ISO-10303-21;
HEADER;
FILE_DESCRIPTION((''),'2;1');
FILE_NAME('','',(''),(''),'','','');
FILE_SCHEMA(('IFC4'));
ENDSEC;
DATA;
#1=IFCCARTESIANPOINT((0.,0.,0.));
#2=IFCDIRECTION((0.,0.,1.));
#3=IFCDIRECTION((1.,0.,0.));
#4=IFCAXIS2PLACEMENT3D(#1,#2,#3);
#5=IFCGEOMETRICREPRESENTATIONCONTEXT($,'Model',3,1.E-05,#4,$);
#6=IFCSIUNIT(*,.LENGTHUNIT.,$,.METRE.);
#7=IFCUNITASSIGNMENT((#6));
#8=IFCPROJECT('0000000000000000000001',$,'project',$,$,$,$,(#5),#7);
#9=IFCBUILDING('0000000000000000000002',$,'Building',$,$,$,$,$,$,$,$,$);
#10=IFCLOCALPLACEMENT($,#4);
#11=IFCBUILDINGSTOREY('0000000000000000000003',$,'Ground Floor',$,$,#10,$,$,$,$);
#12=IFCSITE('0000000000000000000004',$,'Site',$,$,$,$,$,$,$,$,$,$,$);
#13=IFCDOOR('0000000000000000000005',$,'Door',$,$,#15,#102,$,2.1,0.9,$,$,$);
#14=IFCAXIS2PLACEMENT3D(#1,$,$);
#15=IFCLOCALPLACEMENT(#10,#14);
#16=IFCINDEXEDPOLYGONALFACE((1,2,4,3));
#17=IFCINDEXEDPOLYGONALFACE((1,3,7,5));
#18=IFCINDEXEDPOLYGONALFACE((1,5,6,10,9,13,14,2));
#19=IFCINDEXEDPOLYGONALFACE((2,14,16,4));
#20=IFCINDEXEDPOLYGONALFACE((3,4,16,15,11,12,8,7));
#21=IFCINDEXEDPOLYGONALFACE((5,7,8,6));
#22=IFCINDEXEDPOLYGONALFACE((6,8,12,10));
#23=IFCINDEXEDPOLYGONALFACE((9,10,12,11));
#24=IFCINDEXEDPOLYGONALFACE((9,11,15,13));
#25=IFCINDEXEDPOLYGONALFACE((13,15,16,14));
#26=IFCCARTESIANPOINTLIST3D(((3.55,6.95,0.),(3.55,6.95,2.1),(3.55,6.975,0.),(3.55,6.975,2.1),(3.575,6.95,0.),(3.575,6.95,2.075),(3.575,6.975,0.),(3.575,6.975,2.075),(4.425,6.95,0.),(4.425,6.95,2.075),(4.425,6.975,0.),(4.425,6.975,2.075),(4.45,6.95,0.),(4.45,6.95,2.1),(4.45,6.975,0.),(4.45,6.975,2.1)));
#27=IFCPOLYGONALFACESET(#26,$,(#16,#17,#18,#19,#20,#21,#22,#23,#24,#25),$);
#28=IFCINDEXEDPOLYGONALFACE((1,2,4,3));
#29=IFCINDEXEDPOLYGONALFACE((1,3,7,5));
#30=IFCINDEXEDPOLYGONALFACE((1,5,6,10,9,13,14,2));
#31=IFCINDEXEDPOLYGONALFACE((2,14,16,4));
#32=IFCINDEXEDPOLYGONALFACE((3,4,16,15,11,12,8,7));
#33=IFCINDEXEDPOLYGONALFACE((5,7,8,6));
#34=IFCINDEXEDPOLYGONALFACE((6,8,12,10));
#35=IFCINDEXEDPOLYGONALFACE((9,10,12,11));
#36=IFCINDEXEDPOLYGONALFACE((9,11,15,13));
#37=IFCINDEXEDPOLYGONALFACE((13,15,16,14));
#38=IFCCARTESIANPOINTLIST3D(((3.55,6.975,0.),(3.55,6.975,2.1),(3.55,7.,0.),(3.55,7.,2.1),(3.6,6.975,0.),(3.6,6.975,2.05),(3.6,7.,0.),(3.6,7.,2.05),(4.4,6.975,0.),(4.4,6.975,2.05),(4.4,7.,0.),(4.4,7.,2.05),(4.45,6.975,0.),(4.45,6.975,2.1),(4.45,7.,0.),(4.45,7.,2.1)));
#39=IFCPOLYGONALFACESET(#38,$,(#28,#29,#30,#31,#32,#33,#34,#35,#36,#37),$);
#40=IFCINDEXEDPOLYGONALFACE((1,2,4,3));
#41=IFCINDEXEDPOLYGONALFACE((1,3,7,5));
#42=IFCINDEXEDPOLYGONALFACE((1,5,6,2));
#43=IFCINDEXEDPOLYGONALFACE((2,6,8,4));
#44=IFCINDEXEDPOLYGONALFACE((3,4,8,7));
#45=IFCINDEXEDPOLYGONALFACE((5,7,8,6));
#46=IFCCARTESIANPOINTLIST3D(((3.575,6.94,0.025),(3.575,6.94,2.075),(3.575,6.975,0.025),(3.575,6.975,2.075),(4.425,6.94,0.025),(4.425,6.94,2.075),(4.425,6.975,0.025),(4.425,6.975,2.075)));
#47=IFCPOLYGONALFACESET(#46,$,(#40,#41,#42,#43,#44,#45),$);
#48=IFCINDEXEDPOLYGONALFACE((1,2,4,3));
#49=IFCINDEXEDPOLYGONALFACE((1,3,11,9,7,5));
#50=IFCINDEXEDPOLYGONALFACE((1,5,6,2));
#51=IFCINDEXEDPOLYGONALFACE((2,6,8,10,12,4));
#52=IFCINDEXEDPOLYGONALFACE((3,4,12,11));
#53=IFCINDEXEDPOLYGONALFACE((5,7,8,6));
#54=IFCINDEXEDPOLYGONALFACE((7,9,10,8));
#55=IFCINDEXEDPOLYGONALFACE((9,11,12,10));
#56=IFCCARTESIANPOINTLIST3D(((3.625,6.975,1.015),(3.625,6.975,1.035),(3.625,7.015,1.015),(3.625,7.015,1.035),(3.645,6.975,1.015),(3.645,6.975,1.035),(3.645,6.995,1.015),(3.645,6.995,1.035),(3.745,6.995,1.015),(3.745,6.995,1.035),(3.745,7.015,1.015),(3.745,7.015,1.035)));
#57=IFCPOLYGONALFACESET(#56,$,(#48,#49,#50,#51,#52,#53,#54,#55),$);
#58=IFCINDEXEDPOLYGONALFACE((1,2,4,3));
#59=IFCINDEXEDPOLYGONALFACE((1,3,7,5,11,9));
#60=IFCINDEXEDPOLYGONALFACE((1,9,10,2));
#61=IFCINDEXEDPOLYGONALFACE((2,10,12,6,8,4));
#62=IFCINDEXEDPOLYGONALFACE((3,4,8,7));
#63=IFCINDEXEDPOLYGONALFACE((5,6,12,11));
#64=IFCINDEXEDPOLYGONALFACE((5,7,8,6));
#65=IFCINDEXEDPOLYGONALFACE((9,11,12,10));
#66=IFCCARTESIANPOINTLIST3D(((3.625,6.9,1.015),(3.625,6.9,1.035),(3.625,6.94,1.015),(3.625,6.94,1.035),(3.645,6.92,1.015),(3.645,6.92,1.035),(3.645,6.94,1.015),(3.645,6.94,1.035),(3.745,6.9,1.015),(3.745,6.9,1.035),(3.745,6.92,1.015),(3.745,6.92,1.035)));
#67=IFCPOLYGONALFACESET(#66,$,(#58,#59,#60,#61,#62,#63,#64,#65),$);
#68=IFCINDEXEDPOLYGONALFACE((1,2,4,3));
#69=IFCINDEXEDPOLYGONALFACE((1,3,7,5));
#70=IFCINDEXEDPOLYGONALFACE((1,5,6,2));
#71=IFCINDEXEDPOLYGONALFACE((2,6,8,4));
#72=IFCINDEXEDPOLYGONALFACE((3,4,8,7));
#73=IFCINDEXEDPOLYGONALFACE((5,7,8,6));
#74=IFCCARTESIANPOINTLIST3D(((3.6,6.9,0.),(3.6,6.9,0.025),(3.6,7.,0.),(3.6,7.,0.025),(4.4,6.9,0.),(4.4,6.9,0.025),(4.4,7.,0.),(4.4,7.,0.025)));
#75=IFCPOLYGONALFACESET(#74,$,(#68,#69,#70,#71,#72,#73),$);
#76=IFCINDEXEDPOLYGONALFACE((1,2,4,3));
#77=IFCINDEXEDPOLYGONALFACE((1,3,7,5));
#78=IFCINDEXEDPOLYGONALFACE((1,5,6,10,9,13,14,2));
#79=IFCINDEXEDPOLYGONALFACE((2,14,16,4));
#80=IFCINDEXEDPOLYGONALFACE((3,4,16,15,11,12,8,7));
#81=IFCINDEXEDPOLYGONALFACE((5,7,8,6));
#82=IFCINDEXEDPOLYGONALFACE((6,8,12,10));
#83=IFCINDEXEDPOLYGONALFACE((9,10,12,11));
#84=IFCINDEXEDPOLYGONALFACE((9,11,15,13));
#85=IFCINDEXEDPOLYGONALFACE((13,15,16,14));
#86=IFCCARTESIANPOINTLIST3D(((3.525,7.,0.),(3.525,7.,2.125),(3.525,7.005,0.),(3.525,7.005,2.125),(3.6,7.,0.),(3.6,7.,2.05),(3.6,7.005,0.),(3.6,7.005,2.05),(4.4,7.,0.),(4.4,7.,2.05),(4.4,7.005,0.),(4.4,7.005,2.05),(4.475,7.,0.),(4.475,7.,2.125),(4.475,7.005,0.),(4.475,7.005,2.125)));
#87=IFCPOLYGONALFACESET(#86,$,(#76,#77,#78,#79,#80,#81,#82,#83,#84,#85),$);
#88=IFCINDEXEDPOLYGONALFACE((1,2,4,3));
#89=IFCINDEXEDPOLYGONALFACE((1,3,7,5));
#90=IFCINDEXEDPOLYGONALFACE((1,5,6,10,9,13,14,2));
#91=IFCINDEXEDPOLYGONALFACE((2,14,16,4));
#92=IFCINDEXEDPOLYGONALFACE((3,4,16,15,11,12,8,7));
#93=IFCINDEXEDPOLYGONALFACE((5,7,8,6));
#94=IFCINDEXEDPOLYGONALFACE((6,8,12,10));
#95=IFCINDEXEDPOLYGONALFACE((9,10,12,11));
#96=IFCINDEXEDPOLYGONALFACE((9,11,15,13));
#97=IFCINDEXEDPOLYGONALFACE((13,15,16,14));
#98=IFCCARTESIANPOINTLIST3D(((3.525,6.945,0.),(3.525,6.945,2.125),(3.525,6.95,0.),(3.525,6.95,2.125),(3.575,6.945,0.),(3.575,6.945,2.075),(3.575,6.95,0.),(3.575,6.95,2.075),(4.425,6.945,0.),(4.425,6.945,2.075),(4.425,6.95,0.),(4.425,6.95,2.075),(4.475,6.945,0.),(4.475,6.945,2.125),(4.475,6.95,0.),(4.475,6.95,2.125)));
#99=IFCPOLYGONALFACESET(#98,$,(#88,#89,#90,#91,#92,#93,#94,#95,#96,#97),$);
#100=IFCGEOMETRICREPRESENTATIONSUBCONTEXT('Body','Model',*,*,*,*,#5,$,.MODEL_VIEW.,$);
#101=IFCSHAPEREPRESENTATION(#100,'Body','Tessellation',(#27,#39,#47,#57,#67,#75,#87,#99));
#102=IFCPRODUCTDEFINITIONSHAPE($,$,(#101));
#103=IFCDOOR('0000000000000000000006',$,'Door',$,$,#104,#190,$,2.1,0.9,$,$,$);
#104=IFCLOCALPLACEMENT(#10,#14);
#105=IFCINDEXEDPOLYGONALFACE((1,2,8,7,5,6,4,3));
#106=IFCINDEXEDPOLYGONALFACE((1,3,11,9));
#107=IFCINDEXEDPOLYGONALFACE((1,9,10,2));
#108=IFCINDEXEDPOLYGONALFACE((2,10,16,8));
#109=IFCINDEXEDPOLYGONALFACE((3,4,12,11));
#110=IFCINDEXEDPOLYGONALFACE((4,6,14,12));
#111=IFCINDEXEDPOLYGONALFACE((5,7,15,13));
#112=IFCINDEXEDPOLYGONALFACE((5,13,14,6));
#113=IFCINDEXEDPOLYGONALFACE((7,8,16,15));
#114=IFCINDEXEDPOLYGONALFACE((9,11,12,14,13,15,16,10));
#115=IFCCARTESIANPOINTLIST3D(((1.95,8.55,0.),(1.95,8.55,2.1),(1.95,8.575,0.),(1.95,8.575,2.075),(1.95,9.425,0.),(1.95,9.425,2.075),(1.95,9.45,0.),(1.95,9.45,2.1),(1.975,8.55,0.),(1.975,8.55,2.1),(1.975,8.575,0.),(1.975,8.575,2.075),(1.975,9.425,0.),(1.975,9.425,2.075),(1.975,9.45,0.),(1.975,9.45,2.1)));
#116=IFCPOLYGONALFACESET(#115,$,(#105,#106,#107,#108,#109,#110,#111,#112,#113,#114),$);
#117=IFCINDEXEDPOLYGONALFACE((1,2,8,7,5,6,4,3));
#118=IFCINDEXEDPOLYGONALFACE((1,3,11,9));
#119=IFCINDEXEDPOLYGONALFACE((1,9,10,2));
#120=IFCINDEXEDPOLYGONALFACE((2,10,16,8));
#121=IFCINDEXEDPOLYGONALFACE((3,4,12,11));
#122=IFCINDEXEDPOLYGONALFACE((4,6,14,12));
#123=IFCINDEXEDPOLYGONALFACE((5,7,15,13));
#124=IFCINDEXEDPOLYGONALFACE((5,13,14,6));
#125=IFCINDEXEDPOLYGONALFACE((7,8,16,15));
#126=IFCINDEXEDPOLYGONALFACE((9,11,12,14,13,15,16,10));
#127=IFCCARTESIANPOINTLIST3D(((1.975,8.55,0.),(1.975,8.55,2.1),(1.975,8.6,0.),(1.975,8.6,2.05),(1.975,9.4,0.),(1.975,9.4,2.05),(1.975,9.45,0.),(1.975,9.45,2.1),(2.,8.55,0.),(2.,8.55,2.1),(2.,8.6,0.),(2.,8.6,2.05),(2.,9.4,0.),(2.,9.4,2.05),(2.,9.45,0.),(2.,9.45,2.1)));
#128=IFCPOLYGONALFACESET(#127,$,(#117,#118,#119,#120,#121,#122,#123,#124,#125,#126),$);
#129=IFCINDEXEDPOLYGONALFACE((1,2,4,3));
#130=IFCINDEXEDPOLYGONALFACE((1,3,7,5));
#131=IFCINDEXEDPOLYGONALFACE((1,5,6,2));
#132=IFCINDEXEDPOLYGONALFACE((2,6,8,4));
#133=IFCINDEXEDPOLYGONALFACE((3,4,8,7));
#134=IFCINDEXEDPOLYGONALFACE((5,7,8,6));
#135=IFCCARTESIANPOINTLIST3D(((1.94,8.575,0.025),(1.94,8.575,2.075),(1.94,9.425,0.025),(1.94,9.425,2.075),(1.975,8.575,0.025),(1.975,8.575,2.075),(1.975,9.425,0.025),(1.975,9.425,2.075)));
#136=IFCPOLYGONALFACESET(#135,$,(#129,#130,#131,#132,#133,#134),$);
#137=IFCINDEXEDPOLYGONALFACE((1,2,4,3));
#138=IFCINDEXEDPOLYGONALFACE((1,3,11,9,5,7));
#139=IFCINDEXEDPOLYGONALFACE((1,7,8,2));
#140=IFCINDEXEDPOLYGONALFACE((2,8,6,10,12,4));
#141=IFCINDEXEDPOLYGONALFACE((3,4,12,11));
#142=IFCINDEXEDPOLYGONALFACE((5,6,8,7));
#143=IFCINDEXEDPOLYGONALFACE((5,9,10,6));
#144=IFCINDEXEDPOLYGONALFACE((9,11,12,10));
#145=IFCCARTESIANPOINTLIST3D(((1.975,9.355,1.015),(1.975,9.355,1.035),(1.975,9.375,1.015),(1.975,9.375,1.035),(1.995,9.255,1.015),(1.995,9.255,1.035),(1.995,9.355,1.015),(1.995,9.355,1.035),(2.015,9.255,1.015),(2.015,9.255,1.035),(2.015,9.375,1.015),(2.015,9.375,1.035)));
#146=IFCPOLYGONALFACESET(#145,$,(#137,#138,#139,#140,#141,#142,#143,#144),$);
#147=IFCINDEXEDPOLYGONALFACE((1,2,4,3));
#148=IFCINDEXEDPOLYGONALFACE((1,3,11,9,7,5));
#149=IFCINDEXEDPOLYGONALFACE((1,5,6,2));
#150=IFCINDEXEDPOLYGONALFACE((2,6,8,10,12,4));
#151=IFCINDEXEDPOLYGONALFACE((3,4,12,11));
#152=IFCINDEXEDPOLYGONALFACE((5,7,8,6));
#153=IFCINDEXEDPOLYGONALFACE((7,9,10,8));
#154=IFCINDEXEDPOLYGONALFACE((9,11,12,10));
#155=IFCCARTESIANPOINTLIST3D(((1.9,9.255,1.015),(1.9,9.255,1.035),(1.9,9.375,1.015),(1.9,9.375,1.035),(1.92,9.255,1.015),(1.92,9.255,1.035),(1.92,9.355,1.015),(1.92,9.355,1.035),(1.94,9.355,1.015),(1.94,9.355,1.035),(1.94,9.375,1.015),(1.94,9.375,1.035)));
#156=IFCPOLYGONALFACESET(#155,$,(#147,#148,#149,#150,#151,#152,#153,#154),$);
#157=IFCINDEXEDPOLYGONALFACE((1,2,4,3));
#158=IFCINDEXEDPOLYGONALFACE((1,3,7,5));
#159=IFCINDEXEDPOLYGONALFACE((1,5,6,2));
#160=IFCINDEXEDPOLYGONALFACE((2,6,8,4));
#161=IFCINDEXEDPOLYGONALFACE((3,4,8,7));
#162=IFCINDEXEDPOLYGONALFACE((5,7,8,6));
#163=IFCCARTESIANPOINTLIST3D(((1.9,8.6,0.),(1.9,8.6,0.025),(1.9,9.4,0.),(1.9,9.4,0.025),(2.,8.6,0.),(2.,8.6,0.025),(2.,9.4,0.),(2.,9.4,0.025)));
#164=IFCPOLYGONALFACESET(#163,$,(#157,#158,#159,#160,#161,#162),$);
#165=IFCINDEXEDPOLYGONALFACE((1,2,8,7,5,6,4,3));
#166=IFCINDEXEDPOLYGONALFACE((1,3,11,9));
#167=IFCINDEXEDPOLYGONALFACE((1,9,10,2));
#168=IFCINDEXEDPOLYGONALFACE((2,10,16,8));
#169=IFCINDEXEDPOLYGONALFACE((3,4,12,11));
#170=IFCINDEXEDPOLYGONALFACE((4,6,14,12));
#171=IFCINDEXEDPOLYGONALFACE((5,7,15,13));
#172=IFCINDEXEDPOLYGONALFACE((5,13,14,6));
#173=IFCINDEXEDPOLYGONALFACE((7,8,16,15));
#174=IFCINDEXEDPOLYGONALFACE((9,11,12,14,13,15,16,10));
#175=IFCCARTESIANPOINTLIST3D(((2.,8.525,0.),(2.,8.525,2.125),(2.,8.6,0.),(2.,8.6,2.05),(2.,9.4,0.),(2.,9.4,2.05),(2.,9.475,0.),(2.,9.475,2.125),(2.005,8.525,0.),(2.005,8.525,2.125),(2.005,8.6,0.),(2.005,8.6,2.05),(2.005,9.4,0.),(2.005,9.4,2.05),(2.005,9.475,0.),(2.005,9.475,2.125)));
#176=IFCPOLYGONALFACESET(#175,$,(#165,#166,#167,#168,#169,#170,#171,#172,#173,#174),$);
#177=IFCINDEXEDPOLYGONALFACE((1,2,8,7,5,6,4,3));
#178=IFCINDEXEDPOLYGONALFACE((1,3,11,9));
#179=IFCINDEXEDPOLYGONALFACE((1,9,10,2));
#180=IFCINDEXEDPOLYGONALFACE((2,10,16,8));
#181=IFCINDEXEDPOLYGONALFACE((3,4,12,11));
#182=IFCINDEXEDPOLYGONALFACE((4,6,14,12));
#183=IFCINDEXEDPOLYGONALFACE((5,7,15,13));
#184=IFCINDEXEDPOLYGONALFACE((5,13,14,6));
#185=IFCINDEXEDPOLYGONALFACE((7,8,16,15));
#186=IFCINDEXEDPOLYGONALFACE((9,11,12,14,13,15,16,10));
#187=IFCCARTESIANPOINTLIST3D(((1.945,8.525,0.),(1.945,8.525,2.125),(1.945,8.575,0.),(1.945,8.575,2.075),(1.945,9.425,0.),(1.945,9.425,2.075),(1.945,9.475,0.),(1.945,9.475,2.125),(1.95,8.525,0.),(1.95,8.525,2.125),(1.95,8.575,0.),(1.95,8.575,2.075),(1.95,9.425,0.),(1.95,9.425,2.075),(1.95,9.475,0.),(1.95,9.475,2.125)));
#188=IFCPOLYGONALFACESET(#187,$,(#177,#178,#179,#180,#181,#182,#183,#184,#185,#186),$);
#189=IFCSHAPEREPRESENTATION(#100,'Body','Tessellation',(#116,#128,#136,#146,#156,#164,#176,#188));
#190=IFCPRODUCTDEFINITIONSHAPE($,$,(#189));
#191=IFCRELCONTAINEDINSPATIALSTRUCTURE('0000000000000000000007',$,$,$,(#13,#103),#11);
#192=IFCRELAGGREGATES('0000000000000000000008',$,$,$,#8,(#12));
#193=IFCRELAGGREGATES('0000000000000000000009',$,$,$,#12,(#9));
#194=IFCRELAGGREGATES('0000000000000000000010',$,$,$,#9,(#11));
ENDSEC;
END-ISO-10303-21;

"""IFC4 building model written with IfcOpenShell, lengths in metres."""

from ifc_helpers import new_model, si_unit, frame, origin_with_axes, place, context, subcontext, project, spatial, line, indexed_curve, outline, extrude, element, save


model = new_model("IFC4")

# Units and contexts
model_context = context("Model", 3, precision=1e-05, world=origin_with_axes())
body_context = subcontext(model_context, "Body", "Model", "MODEL_VIEW")
ifc_project = project(units=[si_unit("LENGTHUNIT", "METRE")], contexts=[model_context])

# Site, building, storey
site = spatial("IfcSite", under=ifc_project, Name="Site")
building = spatial("IfcBuilding", under=site, Name="Building")
storey_placement = place(None, origin_with_axes())
storey = spatial("IfcBuildingStorey", under=building, at=storey_placement, Name="Ground Floor")

# Doors
door_1_placement = place(storey_placement, frame((4.45, 7.0, 0.0), z_axis=(0.0, 0.0, 1.0), x_axis=(-1.0, 0.0, 0.0)))
element("IfcDoor", 1, at=door_1_placement, inside=storey, Name="Door", OverallHeight=2.1, OverallWidth=0.9, context=body_context, shape_type="SweptSolid", body=[
    extrude(outline(indexed_curve([(0.0, 0.0), (0.0, 2.1), (0.9, 2.1), (0.9, 0.0), (0.875, 0.0), (0.875, 2.075), (0.025, 2.075), (0.025, 0.0)], segments=[line(1, 2, 3, 4, 5, 6, 7, 8, 1)])), frame((0.0, 0.025, 0.0), z_axis=(0.0, -1.0, 0.0), x_axis=(1.0, 0.0, 0.0)), (0.0, 0.0, -1.0), 0.025),
    extrude(outline(indexed_curve([(0.0, 0.0), (0.0, 2.1), (0.9, 2.1), (0.9, 0.0), (0.85, 0.0), (0.85, 2.05), (0.05, 2.05), (0.05, 0.0)], segments=[line(1, 2, 3, 4, 5, 6, 7, 8, 1)])), frame((0.0, 0.0, 0.0), z_axis=(0.0, -1.0, 0.0), x_axis=(1.0, 0.0, 0.0)), (0.0, 0.0, -1.0), 0.025),
    extrude(outline(indexed_curve([(0.0, 0.0), (0.85, 0.0), (0.85, 0.035), (0.0, 0.035)], segments=[line(1, 2, 3, 4, 1)])), frame((0.025, 0.025, 0.025), z_axis=(0.0, 0.0, 1.0), x_axis=(1.0, 0.0, 0.0)), (0.0, 0.0, 1.0), 2.05),
    extrude(outline(indexed_curve([(0.0, 0.0), (0.0, -0.04), (-0.12, -0.04), (-0.12, -0.02), (-0.02, -0.02), (-0.02, 0.0)], segments=[line(1, 2, 3, 4, 5, 6, 1)])), frame((0.825, 0.025, 1.015), z_axis=(0.0, 0.0, 1.0), x_axis=(1.0, 0.0, 0.0)), (0.0, 0.0, 1.0), 0.02),
    extrude(outline(indexed_curve([(0.0, 0.0), (0.0, 0.04), (-0.12, 0.04), (-0.12, 0.02), (-0.02, 0.02), (-0.02, 0.0)], segments=[line(1, 2, 3, 4, 5, 6, 1)])), frame((0.825, 0.06, 1.015), z_axis=(0.0, 0.0, 1.0), x_axis=(1.0, 0.0, 0.0)), (0.0, 0.0, 1.0), 0.02),
    extrude(outline(indexed_curve([(0.0, 0.0), (0.8, 0.0), (0.8, 0.1), (0.0, 0.1)], segments=[line(1, 2, 3, 4, 1)])), frame((0.05, 0.0, 0.0), z_axis=(0.0, 0.0, 1.0), x_axis=(1.0, 0.0, 0.0)), (0.0, 0.0, 1.0), 0.025),
    extrude(outline(indexed_curve([(0.0, 0.0), (0.0, 2.125), (0.95, 2.125), (0.95, 0.0), (0.875, 0.0), (0.875, 2.05), (0.075, 2.05), (0.075, 0.0)], segments=[line(1, 2, 3, 4, 5, 6, 7, 8, 1)])), frame((-0.025, -0.005, 0.0), z_axis=(0.0, -1.0, 0.0), x_axis=(1.0, 0.0, 0.0)), (0.0, 0.0, -1.0), 0.005),
    extrude(outline(indexed_curve([(0.0, 0.0), (0.0, 2.125), (0.95, 2.125), (0.95, 0.0), (0.9, 0.0), (0.9, 2.075), (0.05, 2.075), (0.05, 0.0)], segments=[line(1, 2, 3, 4, 5, 6, 7, 8, 1)])), frame((-0.025, 0.05, 0.0), z_axis=(0.0, -1.0, 0.0), x_axis=(1.0, 0.0, 0.0)), (0.0, 0.0, -1.0), 0.005),
])
door_2_placement = place(storey_placement, frame((2.0, 8.55, 0.0), z_axis=(0.0, 0.0, 1.0), x_axis=(0.0, 1.0, 0.0)))
element("IfcDoor", 2, at=door_2_placement, inside=storey, Name="Door", OverallHeight=2.1, OverallWidth=0.9, context=body_context, shape_type="SweptSolid", body=[
    extrude(outline(indexed_curve([(0.0, 0.0), (0.0, 2.1), (0.9, 2.1), (0.9, 0.0), (0.875, 0.0), (0.875, 2.075), (0.025, 2.075), (0.025, 0.0)], segments=[line(1, 2, 3, 4, 5, 6, 7, 8, 1)])), frame((0.0, 0.025, 0.0), z_axis=(0.0, -1.0, 0.0), x_axis=(1.0, 0.0, 0.0)), (0.0, 0.0, -1.0), 0.025),
    extrude(outline(indexed_curve([(0.0, 0.0), (0.0, 2.1), (0.9, 2.1), (0.9, 0.0), (0.85, 0.0), (0.85, 2.05), (0.05, 2.05), (0.05, 0.0)], segments=[line(1, 2, 3, 4, 5, 6, 7, 8, 1)])), frame((0.0, 0.0, 0.0), z_axis=(0.0, -1.0, 0.0), x_axis=(1.0, 0.0, 0.0)), (0.0, 0.0, -1.0), 0.025),
    extrude(outline(indexed_curve([(0.0, 0.0), (0.85, 0.0), (0.85, 0.035), (0.0, 0.035)], segments=[line(1, 2, 3, 4, 1)])), frame((0.025, 0.025, 0.025), z_axis=(0.0, 0.0, 1.0), x_axis=(1.0, 0.0, 0.0)), (0.0, 0.0, 1.0), 2.05),
    extrude(outline(indexed_curve([(0.0, 0.0), (0.0, -0.04), (-0.12, -0.04), (-0.12, -0.02), (-0.02, -0.02), (-0.02, 0.0)], segments=[line(1, 2, 3, 4, 5, 6, 1)])), frame((0.825, 0.025, 1.015), z_axis=(0.0, 0.0, 1.0), x_axis=(1.0, 0.0, 0.0)), (0.0, 0.0, 1.0), 0.02),
    extrude(outline(indexed_curve([(0.0, 0.0), (0.0, 0.04), (-0.12, 0.04), (-0.12, 0.02), (-0.02, 0.02), (-0.02, 0.0)], segments=[line(1, 2, 3, 4, 5, 6, 1)])), frame((0.825, 0.06, 1.015), z_axis=(0.0, 0.0, 1.0), x_axis=(1.0, 0.0, 0.0)), (0.0, 0.0, 1.0), 0.02),
    extrude(outline(indexed_curve([(0.0, 0.0), (0.8, 0.0), (0.8, 0.1), (0.0, 0.1)], segments=[line(1, 2, 3, 4, 1)])), frame((0.05, 0.0, 0.0), z_axis=(0.0, 0.0, 1.0), x_axis=(1.0, 0.0, 0.0)), (0.0, 0.0, 1.0), 0.025),
    extrude(outline(indexed_curve([(0.0, 0.0), (0.0, 2.125), (0.95, 2.125), (0.95, 0.0), (0.875, 0.0), (0.875, 2.05), (0.075, 2.05), (0.075, 0.0)], segments=[line(1, 2, 3, 4, 5, 6, 7, 8, 1)])), frame((-0.025, -0.005, 0.0), z_axis=(0.0, -1.0, 0.0), x_axis=(1.0, 0.0, 0.0)), (0.0, 0.0, -1.0), 0.005),
    extrude(outline(indexed_curve([(0.0, 0.0), (0.0, 2.125), (0.95, 2.125), (0.95, 0.0), (0.9, 0.0), (0.9, 2.075), (0.05, 2.075), (0.05, 0.0)], segments=[line(1, 2, 3, 4, 5, 6, 7, 8, 1)])), frame((-0.025, 0.05, 0.0), z_axis=(0.0, -1.0, 0.0), x_axis=(1.0, 0.0, 0.0)), (0.0, 0.0, -1.0), 0.005),
])

save(model, "model.ifc")
